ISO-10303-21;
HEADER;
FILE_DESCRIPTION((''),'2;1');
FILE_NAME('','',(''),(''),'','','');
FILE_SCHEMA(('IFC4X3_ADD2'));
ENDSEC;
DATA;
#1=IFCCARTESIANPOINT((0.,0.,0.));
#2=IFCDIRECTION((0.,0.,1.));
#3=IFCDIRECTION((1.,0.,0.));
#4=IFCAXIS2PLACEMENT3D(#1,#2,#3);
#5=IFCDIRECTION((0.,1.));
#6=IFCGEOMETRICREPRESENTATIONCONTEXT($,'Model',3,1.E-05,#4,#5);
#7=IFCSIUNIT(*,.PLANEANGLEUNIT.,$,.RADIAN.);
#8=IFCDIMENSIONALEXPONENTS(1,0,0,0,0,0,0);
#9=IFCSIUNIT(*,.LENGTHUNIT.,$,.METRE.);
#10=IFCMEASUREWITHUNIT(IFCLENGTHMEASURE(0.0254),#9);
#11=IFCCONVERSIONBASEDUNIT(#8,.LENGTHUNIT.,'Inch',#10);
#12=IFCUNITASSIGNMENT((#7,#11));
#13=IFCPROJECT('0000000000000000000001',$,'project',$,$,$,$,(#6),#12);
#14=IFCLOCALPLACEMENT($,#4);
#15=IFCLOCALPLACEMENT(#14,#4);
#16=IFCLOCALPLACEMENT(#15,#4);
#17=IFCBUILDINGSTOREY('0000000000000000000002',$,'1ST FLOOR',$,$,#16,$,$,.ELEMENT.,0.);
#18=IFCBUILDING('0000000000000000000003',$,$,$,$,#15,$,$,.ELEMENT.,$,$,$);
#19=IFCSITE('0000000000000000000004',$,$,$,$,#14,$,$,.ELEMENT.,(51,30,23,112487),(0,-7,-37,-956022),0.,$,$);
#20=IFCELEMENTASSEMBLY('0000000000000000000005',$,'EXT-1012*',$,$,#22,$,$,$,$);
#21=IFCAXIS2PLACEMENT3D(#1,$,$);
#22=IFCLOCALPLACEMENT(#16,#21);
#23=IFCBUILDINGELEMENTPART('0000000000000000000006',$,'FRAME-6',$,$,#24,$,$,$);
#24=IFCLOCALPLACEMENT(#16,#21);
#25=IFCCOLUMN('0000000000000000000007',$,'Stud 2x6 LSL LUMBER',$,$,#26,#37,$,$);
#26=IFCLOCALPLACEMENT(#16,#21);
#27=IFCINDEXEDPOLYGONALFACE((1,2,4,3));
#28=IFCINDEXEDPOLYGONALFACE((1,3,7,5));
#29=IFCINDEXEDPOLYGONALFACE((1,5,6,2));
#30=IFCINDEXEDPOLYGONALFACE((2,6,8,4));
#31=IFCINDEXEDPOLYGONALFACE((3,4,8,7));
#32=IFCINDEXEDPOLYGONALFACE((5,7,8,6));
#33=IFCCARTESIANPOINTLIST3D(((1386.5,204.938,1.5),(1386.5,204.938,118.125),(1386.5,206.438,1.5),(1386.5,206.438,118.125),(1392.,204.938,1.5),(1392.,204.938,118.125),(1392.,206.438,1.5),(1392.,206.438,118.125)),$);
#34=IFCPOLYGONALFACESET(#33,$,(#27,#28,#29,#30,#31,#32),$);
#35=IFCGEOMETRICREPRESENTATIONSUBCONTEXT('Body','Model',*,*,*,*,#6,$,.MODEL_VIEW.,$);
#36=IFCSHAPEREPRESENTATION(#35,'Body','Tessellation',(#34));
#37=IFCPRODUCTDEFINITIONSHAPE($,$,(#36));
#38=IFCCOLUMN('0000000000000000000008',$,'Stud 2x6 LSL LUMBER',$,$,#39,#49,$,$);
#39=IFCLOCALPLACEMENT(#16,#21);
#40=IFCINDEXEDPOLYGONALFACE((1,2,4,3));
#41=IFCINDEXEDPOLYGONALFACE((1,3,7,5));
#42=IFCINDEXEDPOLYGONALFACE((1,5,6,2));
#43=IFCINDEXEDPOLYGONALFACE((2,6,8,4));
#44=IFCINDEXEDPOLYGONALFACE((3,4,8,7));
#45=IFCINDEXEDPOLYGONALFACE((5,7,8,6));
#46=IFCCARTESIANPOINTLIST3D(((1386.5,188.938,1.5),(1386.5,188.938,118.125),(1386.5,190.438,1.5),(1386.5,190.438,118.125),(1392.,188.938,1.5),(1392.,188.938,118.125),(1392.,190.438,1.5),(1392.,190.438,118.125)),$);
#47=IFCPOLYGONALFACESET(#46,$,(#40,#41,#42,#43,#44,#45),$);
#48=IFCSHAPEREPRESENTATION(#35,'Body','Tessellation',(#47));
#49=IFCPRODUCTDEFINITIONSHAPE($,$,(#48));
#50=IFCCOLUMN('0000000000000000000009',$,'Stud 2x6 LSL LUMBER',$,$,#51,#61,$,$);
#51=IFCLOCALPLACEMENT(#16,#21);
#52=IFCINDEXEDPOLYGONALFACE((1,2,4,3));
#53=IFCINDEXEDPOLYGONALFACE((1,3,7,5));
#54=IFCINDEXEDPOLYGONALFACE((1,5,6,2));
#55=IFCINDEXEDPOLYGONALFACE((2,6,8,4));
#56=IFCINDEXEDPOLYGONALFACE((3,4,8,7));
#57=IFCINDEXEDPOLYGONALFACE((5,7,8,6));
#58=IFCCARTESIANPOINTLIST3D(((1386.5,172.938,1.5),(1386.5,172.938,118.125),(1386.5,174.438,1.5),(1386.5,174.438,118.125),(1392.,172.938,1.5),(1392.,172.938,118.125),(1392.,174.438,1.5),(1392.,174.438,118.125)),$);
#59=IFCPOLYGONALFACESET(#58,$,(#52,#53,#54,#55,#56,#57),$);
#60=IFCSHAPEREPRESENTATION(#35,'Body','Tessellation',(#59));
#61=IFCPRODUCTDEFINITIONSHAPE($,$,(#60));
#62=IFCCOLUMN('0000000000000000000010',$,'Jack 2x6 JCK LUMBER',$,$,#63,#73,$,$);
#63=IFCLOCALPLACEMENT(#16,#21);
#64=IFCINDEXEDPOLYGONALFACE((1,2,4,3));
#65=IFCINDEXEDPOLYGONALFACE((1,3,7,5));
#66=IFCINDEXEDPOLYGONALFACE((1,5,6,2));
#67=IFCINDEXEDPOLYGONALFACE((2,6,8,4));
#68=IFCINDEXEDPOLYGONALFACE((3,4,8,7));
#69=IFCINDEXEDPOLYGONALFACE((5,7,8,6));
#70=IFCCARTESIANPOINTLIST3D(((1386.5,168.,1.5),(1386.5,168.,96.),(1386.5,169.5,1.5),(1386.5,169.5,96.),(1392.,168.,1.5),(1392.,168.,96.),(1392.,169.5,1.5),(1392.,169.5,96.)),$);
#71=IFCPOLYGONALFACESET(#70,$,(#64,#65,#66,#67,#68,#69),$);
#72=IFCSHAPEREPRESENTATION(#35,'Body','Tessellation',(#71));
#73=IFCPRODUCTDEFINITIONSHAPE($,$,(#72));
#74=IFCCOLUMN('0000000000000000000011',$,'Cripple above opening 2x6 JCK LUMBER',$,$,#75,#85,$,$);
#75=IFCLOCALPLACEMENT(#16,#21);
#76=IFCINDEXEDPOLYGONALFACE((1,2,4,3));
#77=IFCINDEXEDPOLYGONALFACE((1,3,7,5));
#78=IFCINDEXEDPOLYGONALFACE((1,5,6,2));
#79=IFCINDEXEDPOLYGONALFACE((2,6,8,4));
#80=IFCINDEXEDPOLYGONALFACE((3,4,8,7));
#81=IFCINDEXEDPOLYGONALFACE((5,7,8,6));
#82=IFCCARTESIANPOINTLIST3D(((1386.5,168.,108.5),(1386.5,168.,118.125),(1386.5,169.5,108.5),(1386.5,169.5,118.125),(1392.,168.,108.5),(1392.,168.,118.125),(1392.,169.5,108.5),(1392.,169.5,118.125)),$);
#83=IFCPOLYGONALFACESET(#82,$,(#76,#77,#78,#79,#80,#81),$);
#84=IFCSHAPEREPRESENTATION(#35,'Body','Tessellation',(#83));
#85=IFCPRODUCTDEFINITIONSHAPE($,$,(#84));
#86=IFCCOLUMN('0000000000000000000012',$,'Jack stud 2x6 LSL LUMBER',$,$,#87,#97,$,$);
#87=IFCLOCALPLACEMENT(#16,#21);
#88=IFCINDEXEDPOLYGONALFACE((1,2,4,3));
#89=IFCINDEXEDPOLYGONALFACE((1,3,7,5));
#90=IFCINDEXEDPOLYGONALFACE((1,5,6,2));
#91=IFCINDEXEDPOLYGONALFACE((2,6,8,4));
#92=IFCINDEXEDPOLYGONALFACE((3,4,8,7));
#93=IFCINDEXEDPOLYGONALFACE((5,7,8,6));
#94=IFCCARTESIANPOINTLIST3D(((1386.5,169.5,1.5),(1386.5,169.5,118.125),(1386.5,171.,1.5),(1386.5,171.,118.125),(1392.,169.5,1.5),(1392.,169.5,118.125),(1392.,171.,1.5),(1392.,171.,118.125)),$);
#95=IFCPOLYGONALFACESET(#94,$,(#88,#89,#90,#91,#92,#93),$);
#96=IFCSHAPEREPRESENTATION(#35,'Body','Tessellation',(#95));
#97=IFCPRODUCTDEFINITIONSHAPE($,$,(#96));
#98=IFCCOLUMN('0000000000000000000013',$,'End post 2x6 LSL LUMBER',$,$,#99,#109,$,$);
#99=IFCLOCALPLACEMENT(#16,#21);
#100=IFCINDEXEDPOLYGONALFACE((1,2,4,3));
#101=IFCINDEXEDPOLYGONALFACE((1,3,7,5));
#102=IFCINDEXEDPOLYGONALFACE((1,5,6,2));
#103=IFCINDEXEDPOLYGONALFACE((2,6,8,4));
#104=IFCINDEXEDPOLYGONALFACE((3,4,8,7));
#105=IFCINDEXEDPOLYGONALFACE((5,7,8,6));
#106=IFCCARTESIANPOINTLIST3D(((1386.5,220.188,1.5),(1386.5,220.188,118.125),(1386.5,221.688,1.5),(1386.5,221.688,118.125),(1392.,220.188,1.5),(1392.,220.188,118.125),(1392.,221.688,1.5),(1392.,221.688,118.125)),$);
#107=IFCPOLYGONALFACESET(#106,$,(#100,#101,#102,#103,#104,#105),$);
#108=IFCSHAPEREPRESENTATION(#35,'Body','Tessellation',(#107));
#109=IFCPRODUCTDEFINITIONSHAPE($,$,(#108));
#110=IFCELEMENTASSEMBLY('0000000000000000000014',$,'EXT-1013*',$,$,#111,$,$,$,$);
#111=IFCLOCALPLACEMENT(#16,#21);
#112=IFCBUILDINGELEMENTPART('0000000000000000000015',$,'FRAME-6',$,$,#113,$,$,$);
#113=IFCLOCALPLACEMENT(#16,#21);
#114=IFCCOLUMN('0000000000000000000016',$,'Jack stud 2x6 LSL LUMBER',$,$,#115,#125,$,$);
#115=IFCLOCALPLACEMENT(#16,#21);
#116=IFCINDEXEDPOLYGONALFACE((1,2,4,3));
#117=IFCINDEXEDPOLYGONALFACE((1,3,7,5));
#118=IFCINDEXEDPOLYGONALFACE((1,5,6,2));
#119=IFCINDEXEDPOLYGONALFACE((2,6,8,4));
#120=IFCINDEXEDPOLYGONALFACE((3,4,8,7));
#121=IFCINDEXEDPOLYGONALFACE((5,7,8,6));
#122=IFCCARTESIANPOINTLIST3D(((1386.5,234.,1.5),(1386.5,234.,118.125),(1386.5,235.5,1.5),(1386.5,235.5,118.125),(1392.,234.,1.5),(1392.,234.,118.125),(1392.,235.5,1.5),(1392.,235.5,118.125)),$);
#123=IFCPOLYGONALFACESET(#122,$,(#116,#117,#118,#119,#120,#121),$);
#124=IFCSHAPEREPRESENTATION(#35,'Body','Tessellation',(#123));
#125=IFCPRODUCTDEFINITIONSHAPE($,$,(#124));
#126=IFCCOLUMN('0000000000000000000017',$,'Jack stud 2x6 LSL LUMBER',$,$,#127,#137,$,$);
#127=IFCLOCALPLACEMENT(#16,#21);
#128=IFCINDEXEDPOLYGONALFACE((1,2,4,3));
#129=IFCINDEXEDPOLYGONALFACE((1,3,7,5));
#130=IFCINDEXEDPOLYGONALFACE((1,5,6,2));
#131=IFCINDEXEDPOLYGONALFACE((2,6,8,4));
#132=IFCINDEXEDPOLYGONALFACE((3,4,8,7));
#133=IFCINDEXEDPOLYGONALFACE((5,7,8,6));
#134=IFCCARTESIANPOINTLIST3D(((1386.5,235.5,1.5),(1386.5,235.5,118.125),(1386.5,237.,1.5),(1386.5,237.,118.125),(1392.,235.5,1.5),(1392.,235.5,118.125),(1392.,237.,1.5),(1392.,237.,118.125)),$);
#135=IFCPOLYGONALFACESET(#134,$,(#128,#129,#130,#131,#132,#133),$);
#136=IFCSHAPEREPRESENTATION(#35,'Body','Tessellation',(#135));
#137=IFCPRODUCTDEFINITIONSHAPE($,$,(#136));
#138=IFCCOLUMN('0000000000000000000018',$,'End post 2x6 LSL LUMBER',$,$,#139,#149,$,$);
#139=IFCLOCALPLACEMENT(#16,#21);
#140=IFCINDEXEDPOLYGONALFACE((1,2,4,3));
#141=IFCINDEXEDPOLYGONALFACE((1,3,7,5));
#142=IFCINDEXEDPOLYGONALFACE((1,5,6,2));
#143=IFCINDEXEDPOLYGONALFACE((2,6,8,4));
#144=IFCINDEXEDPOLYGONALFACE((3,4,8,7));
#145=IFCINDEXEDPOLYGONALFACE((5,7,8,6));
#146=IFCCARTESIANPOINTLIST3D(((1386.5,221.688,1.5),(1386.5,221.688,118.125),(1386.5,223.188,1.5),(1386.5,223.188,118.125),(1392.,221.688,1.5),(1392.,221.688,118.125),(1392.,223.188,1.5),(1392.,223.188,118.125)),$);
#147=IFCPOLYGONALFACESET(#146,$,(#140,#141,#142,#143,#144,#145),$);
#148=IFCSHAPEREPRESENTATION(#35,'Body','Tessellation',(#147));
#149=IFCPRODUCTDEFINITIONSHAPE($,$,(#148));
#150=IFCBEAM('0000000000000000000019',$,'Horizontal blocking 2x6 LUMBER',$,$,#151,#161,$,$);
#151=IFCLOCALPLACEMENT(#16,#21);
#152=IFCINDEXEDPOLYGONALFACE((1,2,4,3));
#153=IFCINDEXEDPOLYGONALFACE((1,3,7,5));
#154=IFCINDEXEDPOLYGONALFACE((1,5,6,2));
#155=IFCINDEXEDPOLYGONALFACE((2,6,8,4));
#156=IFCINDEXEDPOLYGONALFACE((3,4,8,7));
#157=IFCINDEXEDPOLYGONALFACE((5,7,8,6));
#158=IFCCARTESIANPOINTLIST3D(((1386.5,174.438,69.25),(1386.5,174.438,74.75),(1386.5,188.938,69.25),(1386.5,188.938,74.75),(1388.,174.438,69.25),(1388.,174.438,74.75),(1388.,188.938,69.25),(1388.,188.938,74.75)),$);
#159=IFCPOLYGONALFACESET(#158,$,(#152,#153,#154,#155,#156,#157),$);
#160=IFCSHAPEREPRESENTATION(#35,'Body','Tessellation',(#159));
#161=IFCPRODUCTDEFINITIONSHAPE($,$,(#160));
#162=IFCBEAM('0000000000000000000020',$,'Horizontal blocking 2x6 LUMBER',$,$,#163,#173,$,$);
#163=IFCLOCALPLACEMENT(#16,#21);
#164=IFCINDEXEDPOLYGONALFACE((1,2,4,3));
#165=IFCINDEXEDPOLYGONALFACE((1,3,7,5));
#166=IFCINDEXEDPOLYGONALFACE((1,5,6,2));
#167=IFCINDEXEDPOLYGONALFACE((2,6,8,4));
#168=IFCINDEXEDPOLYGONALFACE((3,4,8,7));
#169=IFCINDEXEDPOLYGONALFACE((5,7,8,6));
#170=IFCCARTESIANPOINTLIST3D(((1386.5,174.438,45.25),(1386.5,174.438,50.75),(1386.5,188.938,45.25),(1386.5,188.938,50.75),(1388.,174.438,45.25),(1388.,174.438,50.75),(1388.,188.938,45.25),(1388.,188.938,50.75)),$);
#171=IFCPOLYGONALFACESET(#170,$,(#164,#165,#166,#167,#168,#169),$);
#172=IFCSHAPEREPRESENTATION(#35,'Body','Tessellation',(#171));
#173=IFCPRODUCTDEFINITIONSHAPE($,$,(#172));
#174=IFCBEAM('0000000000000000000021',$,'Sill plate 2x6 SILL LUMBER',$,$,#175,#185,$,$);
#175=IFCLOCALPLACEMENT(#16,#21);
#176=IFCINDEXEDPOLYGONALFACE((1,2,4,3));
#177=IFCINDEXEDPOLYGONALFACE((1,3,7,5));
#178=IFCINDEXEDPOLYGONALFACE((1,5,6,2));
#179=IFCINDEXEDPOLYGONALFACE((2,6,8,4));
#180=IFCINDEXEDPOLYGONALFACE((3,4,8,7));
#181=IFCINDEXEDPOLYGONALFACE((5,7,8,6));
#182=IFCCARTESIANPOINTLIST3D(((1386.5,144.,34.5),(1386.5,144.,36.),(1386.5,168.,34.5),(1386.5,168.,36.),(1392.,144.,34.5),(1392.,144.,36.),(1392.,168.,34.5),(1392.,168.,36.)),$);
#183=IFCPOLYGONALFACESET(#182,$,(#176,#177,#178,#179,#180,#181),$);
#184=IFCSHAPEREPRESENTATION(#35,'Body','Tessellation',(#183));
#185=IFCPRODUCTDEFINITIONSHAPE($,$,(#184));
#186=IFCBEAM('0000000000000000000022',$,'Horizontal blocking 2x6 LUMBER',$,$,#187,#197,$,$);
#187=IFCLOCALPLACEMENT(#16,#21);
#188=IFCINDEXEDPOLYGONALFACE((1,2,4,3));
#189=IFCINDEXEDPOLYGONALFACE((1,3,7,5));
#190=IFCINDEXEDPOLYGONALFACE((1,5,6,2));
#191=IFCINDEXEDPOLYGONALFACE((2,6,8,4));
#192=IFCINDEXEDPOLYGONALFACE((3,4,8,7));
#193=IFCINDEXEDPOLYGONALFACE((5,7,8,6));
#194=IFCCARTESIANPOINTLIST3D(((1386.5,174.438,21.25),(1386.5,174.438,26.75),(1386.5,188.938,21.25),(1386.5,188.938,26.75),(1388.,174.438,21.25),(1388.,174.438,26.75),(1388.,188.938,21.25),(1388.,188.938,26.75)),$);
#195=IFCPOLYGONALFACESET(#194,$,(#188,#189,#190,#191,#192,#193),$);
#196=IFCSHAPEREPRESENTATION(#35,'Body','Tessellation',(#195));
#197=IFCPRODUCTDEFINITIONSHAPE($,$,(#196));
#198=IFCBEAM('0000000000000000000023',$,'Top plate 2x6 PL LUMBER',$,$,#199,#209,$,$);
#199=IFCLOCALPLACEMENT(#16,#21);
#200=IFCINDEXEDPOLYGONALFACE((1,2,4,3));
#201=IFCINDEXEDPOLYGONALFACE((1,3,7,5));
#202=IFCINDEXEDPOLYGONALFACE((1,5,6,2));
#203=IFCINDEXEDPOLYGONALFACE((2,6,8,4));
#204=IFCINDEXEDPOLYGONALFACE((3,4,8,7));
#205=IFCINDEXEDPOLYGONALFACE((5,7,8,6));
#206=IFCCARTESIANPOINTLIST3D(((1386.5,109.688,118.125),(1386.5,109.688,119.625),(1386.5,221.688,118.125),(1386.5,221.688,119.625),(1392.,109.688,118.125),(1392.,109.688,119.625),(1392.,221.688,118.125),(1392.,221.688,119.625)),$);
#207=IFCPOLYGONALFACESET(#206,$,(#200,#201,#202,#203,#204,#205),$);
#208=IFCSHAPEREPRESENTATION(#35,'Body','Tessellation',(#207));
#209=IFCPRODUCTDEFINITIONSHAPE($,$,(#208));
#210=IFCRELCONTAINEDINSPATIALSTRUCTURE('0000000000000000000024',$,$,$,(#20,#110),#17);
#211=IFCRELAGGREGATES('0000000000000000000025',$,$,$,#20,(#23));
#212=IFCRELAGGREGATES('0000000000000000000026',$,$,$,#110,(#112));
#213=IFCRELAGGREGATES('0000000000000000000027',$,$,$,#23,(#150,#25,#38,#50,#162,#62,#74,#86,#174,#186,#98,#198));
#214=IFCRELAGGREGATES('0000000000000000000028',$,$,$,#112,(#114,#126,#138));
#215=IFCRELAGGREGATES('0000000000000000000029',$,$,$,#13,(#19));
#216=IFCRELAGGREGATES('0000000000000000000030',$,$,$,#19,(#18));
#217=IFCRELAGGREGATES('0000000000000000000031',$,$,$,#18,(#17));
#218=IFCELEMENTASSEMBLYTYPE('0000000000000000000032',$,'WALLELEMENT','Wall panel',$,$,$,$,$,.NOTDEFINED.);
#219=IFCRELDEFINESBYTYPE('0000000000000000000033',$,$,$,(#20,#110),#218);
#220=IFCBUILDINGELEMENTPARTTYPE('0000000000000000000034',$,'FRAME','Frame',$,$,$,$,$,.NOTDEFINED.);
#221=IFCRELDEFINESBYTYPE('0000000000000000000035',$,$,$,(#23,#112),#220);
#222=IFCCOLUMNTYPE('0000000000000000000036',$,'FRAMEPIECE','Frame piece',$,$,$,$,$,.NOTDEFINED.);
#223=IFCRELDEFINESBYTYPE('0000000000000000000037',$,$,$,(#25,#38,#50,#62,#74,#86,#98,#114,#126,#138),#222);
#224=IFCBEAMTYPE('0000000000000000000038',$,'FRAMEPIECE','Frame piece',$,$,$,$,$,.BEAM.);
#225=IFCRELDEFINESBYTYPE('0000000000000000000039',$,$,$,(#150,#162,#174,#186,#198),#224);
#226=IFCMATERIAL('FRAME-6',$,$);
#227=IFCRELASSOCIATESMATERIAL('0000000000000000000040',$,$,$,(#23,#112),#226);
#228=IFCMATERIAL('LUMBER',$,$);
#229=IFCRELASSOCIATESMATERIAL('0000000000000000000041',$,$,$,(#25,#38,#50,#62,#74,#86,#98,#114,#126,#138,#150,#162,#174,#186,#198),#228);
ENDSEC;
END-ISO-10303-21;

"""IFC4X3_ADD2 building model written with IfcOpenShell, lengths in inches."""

from ifc_helpers import new_model, entity, si_unit, converted_unit, direction, frame, origin_with_axes, origin_2d_with_axis, place, context, subcontext, project, spatial, rectangle, extrude, material, type_object, element, aggregate, save


model = new_model("IFC4X3_ADD2")

# Units and contexts
model_context = context("Model", 3, precision=1e-05, world=origin_with_axes(), true_north=direction((0.0, 1.0)))
body_context = subcontext(model_context, "Body", "Model", "MODEL_VIEW")
ifc_project = project(units=[si_unit("PLANEANGLEUNIT", "RADIAN"), converted_unit("LENGTHUNIT", "Inch", entity("IfcLengthMeasure", 0.0254), si_unit("LENGTHUNIT", "METRE"), dimensions=[1, 0, 0, 0, 0, 0, 0])], contexts=[model_context])

# Site, building, storey
site_placement = place(None, origin_with_axes())
site = spatial("IfcSite", under=ifc_project, at=site_placement, CompositionType="ELEMENT", RefLatitude=(51, 30, 23, 112487), RefLongitude=(0, -7, -37, -956022), RefElevation=0.0)
building_placement = place(site_placement, origin_with_axes())
building = spatial("IfcBuilding", under=site, at=building_placement, CompositionType="ELEMENT")
storey_placement = place(building_placement, origin_with_axes())
storey = spatial("IfcBuildingStorey", under=building, at=storey_placement, Name="1ST FLOOR", CompositionType="ELEMENT", Elevation=0.0)

# Element assemblies, building element parts, columns
element_assembly_type_1 = type_object("IfcElementAssemblyType", Name="WALLELEMENT", Description="Wall panel", PredefinedType="NOTDEFINED")
assembly_1_placement = place(storey_placement, origin_with_axes())
assembly_1 = element("IfcElementAssembly", 1, at=assembly_1_placement, inside=storey, type_object=element_assembly_type_1, Name="EXT-1012*")
ifc_material_1 = material(Name="FRAME-6")
building_element_part_type = type_object("IfcBuildingElementPartType", Name="FRAME", Description="Frame", PredefinedType="NOTDEFINED")
building_element_part_1_placement = place(storey_placement, origin_with_axes())
building_element_part_1 = element("IfcBuildingElementPart", 2, at=building_element_part_1_placement, type_object=building_element_part_type, material=ifc_material_1, Name="FRAME-6")
aggregate(assembly_1, [building_element_part_1])
ifc_material_2 = material(Name="LUMBER")
column_type = type_object("IfcColumnType", Name="FRAMEPIECE", Description="Frame piece", PredefinedType="NOTDEFINED")
column_1_placement = place(storey_placement, frame((1389.25, 205.688, 118.125), z_axis=(0.0, 0.0, -1.0), x_axis=(0.0, 1.0, 0.0)))
column_1 = element("IfcColumn", 3, at=column_1_placement, type_object=column_type, material=ifc_material_2, Name="Stud 2x6 LSL LUMBER", context=body_context, shape_type="SweptSolid", body=[
    extrude(rectangle(XDim=1.5, YDim=5.5, at=origin_2d_with_axis()), origin_with_axes(), (0.0, 0.0, 1.0), 116.625),
])
column_2_placement = place(storey_placement, frame((1389.25, 189.688, 118.125), z_axis=(0.0, 0.0, -1.0), x_axis=(0.0, 1.0, 0.0)))
column_2 = element("IfcColumn", 4, at=column_2_placement, type_object=column_type, material=ifc_material_2, Name="Stud 2x6 LSL LUMBER", context=body_context, shape_type="SweptSolid", body=[
    extrude(rectangle(XDim=1.5, YDim=5.5, at=origin_2d_with_axis()), origin_with_axes(), (0.0, 0.0, 1.0), 116.625),
])
column_3_placement = place(storey_placement, frame((1389.25, 173.688, 118.125), z_axis=(0.0, 0.0, -1.0), x_axis=(0.0, 1.0, 0.0)))
column_3 = element("IfcColumn", 5, at=column_3_placement, type_object=column_type, material=ifc_material_2, Name="Stud 2x6 LSL LUMBER", context=body_context, shape_type="SweptSolid", body=[
    extrude(rectangle(XDim=1.5, YDim=5.5, at=origin_2d_with_axis()), origin_with_axes(), (0.0, 0.0, 1.0), 116.625),
])
column_4_placement = place(storey_placement, frame((1389.25, 168.75, 1.5), z_axis=(0.0, 0.0, 1.0), x_axis=(0.0, -1.0, 0.0)))
column_4 = element("IfcColumn", 6, at=column_4_placement, type_object=column_type, material=ifc_material_2, Name="Jack 2x6 JCK LUMBER", context=body_context, shape_type="SweptSolid", body=[
    extrude(rectangle(XDim=1.5, YDim=5.5, at=origin_2d_with_axis()), origin_with_axes(), (0.0, 0.0, 1.0), 94.5),
])
column_5_placement = place(storey_placement, frame((1389.25, 168.75, 108.5), z_axis=(0.0, 0.0, 1.0), x_axis=(0.0, -1.0, 0.0)))
column_5 = element("IfcColumn", 7, at=column_5_placement, type_object=column_type, material=ifc_material_2, Name="Cripple above opening 2x6 JCK LUMBER", context=body_context, shape_type="SweptSolid", body=[
    extrude(rectangle(XDim=1.5, YDim=5.5, at=origin_2d_with_axis()), origin_with_axes(), (0.0, 0.0, 1.0), 9.625),
])
column_6_placement = place(storey_placement, frame((1389.25, 170.25, 1.5), z_axis=(0.0, 0.0, 1.0), x_axis=(0.0, -1.0, 0.0)))
column_6 = element("IfcColumn", 8, at=column_6_placement, type_object=column_type, material=ifc_material_2, Name="Jack stud 2x6 LSL LUMBER", context=body_context, shape_type="SweptSolid", body=[
    extrude(rectangle(XDim=1.5, YDim=5.5, at=origin_2d_with_axis()), origin_with_axes(), (0.0, 0.0, 1.0), 116.625),
])
column_7_placement = place(storey_placement, frame((1389.25, 220.938, 1.5), z_axis=(0.0, 0.0, 1.0), x_axis=(0.0, -1.0, 0.0)))
column_7 = element("IfcColumn", 9, at=column_7_placement, type_object=column_type, material=ifc_material_2, Name="End post 2x6 LSL LUMBER", context=body_context, shape_type="SweptSolid", body=[
    extrude(rectangle(XDim=1.5, YDim=5.5, at=origin_2d_with_axis()), origin_with_axes(), (0.0, 0.0, 1.0), 116.625),
])
assembly_2_placement = place(storey_placement, origin_with_axes())
assembly_2 = element("IfcElementAssembly", 10, at=assembly_2_placement, inside=storey, type_object=element_assembly_type_1, Name="EXT-1013*")
building_element_part_2_placement = place(storey_placement, origin_with_axes())
building_element_part_2 = element("IfcBuildingElementPart", 11, at=building_element_part_2_placement, type_object=building_element_part_type, material=ifc_material_1, Name="FRAME-6")
aggregate(assembly_2, [building_element_part_2])
column_8_placement = place(storey_placement, frame((1389.25, 234.75, 118.125), z_axis=(0.0, 0.0, -1.0), x_axis=(0.0, 1.0, 0.0)))
column_8 = element("IfcColumn", 12, at=column_8_placement, type_object=column_type, material=ifc_material_2, Name="Jack stud 2x6 LSL LUMBER", context=body_context, shape_type="SweptSolid", body=[
    extrude(rectangle(XDim=1.5, YDim=5.5, at=origin_2d_with_axis()), origin_with_axes(), (0.0, 0.0, 1.0), 116.625),
])
column_9_placement = place(storey_placement, frame((1389.25, 236.25, 118.125), z_axis=(0.0, 0.0, -1.0), x_axis=(0.0, 1.0, 0.0)))
column_9 = element("IfcColumn", 13, at=column_9_placement, type_object=column_type, material=ifc_material_2, Name="Jack stud 2x6 LSL LUMBER", context=body_context, shape_type="SweptSolid", body=[
    extrude(rectangle(XDim=1.5, YDim=5.5, at=origin_2d_with_axis()), origin_with_axes(), (0.0, 0.0, 1.0), 116.625),
])
column_10_placement = place(storey_placement, frame((1389.25, 222.438, 118.125), z_axis=(0.0, 0.0, -1.0), x_axis=(0.0, 1.0, 0.0)))
column_10 = element("IfcColumn", 14, at=column_10_placement, type_object=column_type, material=ifc_material_2, Name="End post 2x6 LSL LUMBER", context=body_context, shape_type="SweptSolid", body=[
    extrude(rectangle(XDim=1.5, YDim=5.5, at=origin_2d_with_axis()), origin_with_axes(), (0.0, 0.0, 1.0), 116.625),
])

# Beams
beam_type_1 = type_object("IfcBeamType", Name="FRAMEPIECE", Description="Frame piece", PredefinedType="BEAM")
beam_1_placement = place(storey_placement, frame((1387.25, 188.938, 72.0), z_axis=(0.0, -1.0, 0.0), x_axis=(-1.0, 0.0, 0.0)))
beam_1 = element("IfcBeam", 15, at=beam_1_placement, type_object=beam_type_1, material=ifc_material_2, Name="Horizontal blocking 2x6 LUMBER", context=body_context, shape_type="SweptSolid", body=[
    extrude(rectangle(XDim=1.5, YDim=5.5, at=origin_2d_with_axis()), origin_with_axes(), (0.0, 0.0, 1.0), 14.5),
])
beam_2_placement = place(storey_placement, frame((1387.25, 188.938, 48.0), z_axis=(0.0, -1.0, 0.0), x_axis=(-1.0, 0.0, 0.0)))
beam_2 = element("IfcBeam", 16, at=beam_2_placement, type_object=beam_type_1, material=ifc_material_2, Name="Horizontal blocking 2x6 LUMBER", context=body_context, shape_type="SweptSolid", body=[
    extrude(rectangle(XDim=1.5, YDim=5.5, at=origin_2d_with_axis()), origin_with_axes(), (0.0, 0.0, 1.0), 14.5),
])
beam_3_placement = place(storey_placement, frame((1389.25, 168.0, 35.25), z_axis=(0.0, -1.0, 0.0), x_axis=(0.0, 0.0, -1.0)))
beam_3 = element("IfcBeam", 17, at=beam_3_placement, type_object=beam_type_1, material=ifc_material_2, Name="Sill plate 2x6 SILL LUMBER", context=body_context, shape_type="SweptSolid", body=[
    extrude(rectangle(XDim=1.5, YDim=5.5, at=origin_2d_with_axis()), origin_with_axes(), (0.0, 0.0, 1.0), 24.0),
])
beam_4_placement = place(storey_placement, frame((1387.25, 188.938, 24.0), z_axis=(0.0, -1.0, 0.0), x_axis=(-1.0, 0.0, 0.0)))
beam_4 = element("IfcBeam", 18, at=beam_4_placement, type_object=beam_type_1, material=ifc_material_2, Name="Horizontal blocking 2x6 LUMBER", context=body_context, shape_type="SweptSolid", body=[
    extrude(rectangle(XDim=1.5, YDim=5.5, at=origin_2d_with_axis()), origin_with_axes(), (0.0, 0.0, 1.0), 14.5),
])
beam_5_placement = place(storey_placement, frame((1389.25, 221.688, 118.875), z_axis=(0.0, -1.0, 0.0), x_axis=(0.0, 0.0, -1.0)))
beam_5 = element("IfcBeam", 19, at=beam_5_placement, type_object=beam_type_1, material=ifc_material_2, Name="Top plate 2x6 PL LUMBER", context=body_context, shape_type="SweptSolid", body=[
    extrude(rectangle(XDim=1.5, YDim=5.5, at=origin_2d_with_axis()), origin_with_axes(), (0.0, 0.0, 1.0), 112.0),
])
aggregate(building_element_part_1, [beam_1, column_1, column_2, column_3, beam_2, column_4, column_5, column_6, beam_3, beam_4, column_7, beam_5])
aggregate(building_element_part_2, [column_8, column_9, column_10])

save(model, "model.ifc")
